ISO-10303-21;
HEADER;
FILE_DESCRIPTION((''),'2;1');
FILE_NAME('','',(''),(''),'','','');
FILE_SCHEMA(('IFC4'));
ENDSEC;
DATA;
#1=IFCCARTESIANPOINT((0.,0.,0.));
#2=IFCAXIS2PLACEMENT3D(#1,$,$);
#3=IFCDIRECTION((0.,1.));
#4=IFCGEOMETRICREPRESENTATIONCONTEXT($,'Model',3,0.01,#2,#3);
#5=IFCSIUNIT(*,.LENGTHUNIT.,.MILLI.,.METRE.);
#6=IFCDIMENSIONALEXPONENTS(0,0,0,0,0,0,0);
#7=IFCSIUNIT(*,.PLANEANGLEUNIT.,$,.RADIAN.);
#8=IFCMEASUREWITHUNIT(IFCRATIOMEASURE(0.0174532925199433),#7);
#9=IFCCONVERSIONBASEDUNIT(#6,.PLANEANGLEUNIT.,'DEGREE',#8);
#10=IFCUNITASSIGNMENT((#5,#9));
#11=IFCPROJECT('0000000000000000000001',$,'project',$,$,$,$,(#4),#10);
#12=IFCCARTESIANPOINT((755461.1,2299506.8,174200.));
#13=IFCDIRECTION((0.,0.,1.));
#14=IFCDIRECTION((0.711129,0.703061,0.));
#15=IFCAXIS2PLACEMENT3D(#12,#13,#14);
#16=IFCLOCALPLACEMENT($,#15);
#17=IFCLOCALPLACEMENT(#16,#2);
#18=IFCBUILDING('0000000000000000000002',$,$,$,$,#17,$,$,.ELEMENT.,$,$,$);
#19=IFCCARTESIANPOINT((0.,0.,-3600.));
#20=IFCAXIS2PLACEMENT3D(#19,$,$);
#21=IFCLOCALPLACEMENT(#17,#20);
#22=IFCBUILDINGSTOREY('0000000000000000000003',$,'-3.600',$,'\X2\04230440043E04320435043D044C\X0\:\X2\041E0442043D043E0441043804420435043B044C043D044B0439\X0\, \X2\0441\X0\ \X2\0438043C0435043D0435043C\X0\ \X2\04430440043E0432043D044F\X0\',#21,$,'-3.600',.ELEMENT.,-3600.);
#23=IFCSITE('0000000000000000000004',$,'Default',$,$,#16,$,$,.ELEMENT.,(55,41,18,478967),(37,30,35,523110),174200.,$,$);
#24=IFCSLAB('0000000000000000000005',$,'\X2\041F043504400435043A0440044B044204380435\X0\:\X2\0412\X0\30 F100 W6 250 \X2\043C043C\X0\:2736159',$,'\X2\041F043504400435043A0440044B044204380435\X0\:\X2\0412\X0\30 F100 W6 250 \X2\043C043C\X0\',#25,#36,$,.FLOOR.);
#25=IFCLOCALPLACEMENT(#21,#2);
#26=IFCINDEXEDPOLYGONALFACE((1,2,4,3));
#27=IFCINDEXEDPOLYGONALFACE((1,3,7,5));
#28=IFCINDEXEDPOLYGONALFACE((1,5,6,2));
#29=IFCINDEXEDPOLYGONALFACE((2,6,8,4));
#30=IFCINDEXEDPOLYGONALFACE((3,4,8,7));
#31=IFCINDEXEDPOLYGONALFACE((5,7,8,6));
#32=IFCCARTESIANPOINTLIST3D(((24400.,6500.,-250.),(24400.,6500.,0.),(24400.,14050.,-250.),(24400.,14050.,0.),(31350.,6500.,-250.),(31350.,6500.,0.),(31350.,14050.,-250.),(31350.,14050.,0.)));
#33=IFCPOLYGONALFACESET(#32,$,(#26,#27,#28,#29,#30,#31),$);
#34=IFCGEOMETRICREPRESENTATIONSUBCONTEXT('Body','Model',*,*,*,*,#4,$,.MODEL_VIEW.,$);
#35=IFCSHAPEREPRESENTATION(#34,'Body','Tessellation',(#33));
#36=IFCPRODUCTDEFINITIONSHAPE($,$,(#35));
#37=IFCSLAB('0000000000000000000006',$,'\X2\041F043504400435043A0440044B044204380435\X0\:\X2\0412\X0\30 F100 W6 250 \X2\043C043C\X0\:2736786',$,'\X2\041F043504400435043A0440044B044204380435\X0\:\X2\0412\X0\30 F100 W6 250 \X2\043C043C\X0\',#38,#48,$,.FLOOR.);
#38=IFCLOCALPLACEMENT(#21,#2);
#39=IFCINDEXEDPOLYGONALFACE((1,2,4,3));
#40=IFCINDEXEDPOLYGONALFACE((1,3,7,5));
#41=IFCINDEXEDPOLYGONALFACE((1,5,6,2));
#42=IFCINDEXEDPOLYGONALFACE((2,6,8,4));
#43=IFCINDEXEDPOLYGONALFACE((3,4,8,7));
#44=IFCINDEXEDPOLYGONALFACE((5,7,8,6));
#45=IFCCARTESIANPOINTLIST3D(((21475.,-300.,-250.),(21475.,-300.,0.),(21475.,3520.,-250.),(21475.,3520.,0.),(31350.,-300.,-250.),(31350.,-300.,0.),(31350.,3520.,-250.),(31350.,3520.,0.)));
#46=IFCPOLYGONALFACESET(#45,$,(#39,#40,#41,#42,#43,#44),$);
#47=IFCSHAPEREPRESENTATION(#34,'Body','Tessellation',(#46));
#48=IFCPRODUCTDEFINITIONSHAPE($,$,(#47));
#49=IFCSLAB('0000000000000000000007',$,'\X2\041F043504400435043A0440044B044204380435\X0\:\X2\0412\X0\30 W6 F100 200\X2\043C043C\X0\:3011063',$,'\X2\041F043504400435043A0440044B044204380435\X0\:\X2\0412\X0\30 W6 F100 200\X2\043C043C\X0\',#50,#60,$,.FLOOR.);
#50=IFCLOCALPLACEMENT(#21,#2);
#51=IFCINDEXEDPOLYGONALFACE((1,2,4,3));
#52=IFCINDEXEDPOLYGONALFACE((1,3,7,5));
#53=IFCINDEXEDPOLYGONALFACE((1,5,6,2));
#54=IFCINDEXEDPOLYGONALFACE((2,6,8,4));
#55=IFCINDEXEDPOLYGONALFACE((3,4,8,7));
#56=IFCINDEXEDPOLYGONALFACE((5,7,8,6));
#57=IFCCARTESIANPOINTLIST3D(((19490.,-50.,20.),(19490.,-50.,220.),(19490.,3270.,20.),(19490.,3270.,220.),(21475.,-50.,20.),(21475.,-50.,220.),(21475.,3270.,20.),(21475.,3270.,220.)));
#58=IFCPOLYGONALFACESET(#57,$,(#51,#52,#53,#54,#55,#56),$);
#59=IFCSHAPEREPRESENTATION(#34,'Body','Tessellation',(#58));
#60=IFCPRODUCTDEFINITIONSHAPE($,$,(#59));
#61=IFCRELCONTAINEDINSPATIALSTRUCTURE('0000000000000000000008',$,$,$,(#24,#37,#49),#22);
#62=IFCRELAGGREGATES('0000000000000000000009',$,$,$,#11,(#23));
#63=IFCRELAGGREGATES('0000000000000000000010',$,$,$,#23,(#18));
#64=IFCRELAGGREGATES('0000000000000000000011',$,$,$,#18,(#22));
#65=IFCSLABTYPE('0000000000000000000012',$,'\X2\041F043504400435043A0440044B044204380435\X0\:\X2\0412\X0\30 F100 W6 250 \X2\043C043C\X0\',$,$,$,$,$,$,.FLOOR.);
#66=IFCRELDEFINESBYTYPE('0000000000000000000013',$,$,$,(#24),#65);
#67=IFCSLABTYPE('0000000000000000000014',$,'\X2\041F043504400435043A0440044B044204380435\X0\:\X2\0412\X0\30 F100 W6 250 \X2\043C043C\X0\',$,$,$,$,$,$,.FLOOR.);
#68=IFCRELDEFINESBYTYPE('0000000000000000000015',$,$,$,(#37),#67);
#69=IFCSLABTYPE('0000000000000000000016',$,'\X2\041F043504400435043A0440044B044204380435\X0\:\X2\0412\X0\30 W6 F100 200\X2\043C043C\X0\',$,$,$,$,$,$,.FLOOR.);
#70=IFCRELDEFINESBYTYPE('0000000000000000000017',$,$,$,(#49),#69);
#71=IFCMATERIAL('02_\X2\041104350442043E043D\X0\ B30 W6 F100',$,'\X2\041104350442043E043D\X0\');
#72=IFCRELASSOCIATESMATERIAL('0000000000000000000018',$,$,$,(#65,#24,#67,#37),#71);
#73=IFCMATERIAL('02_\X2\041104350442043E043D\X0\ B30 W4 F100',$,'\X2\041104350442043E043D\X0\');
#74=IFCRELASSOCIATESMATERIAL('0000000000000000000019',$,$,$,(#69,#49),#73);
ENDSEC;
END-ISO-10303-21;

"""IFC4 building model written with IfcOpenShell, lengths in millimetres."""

from ifc_helpers import new_model, entity, si_unit, converted_unit, direction, frame, origin, place, context, subcontext, project, spatial, indexed_curve, outline, extrude, material, type_object, element, save


model = new_model("IFC4")

# Units and contexts
model_context = context("Model", 3, precision=0.01, world=origin(), true_north=direction((0.0, 1.0)))
body_context = subcontext(model_context, "Body", "Model", "MODEL_VIEW")
ifc_project = project(units=[si_unit("LENGTHUNIT", "METRE", prefix="MILLI"), converted_unit("PLANEANGLEUNIT", "DEGREE", entity("IfcRatioMeasure", 0.0174532925199433), si_unit("PLANEANGLEUNIT", "RADIAN"), dimensions=[0, 0, 0, 0, 0, 0, 0])], contexts=[model_context])

# Site, building, storey
site_placement = place(None, frame((755461.1, 2299506.8, 174200.0), z_axis=(0.0, 0.0, 1.0), x_axis=(0.711129, 0.703061, 0.0)))
site = spatial("IfcSite", under=ifc_project, at=site_placement, Name="Default", CompositionType="ELEMENT", RefLatitude=(55, 41, 18, 478967), RefLongitude=(37, 30, 35, 523110), RefElevation=174200.0)
building_placement = place(site_placement, origin())
building = spatial("IfcBuilding", under=site, at=building_placement, CompositionType="ELEMENT")
storey_placement = place(building_placement, frame((0.0, 0.0, -3600.0)))
storey = spatial("IfcBuildingStorey", under=building, at=storey_placement, Name="-3.600", ObjectType="Уровень:Относительный, с именем уровня", LongName="-3.600", CompositionType="ELEMENT", Elevation=-3600.0)

# Slabs
ifc_material_1 = material(Name="02_Бетон B30 W6 F100", Category="Бетон")
slab_type_1 = type_object("IfcSlabType", Name="Перекрытие:В30 F100 W6 250 мм", PredefinedType="FLOOR", material=ifc_material_1)
slab_1_placement = place(storey_placement, origin())
element("IfcSlab", 1, at=slab_1_placement, inside=storey, type_object=slab_type_1, material=ifc_material_1, Name="Перекрытие:В30 F100 W6 250 мм:2736159", ObjectType="Перекрытие:В30 F100 W6 250 мм", PredefinedType="FLOOR", context=body_context, shape_type="SweptSolid", body=[
    extrude(outline(indexed_curve([(-3775.0, -3475.0), (3775.0, -3475.0), (3775.0, 3475.0), (-3775.0, 3475.0), (-3775.0, -3475.0)], self_intersect=False)), frame((27875.0, 10275.0, 0.0), z_axis=(0.0, 0.0, -1.0), x_axis=(0.0, 1.0, 0.0)), (0.0, 0.0, 1.0), 250.0),
])
slab_type_2 = type_object("IfcSlabType", Name="Перекрытие:В30 F100 W6 250 мм", PredefinedType="FLOOR", material=ifc_material_1)
slab_2_placement = place(storey_placement, origin())
element("IfcSlab", 2, at=slab_2_placement, inside=storey, type_object=slab_type_2, material=ifc_material_1, Name="Перекрытие:В30 F100 W6 250 мм:2736786", ObjectType="Перекрытие:В30 F100 W6 250 мм", PredefinedType="FLOOR", context=body_context, shape_type="SweptSolid", body=[
    extrude(outline(indexed_curve([(-1910.0, -4937.5), (1910.0, -4937.5), (1910.0, 4937.5), (-1910.0, 4937.5), (-1910.0, -4937.5)], self_intersect=False)), frame((26412.5, 1610.0, 0.0), z_axis=(0.0, 0.0, -1.0), x_axis=(0.0, 1.0, 0.0)), (0.0, 0.0, 1.0), 250.0),
])
ifc_material_2 = material(Name="02_Бетон B30 W4 F100", Category="Бетон")
slab_type_3 = type_object("IfcSlabType", Name="Перекрытие:В30 W6 F100 200мм", PredefinedType="FLOOR", material=ifc_material_2)
slab_3_placement = place(storey_placement, origin())
element("IfcSlab", 3, at=slab_3_placement, inside=storey, type_object=slab_type_3, material=ifc_material_2, Name="Перекрытие:В30 W6 F100 200мм:3011063", ObjectType="Перекрытие:В30 W6 F100 200мм", PredefinedType="FLOOR", context=body_context, shape_type="SweptSolid", body=[
    extrude(outline(indexed_curve([(-1660.0, -992.5), (1660.0, -992.5), (1660.0, 992.5), (-1660.0, 992.5), (-1660.0, -992.5)], self_intersect=False)), frame((20482.5, 1610.0, 220.0), z_axis=(0.0, 0.0, -1.0), x_axis=(0.0, 1.0, 0.0)), (0.0, 0.0, 1.0), 200.0),
])

save(model, "model.ifc")
